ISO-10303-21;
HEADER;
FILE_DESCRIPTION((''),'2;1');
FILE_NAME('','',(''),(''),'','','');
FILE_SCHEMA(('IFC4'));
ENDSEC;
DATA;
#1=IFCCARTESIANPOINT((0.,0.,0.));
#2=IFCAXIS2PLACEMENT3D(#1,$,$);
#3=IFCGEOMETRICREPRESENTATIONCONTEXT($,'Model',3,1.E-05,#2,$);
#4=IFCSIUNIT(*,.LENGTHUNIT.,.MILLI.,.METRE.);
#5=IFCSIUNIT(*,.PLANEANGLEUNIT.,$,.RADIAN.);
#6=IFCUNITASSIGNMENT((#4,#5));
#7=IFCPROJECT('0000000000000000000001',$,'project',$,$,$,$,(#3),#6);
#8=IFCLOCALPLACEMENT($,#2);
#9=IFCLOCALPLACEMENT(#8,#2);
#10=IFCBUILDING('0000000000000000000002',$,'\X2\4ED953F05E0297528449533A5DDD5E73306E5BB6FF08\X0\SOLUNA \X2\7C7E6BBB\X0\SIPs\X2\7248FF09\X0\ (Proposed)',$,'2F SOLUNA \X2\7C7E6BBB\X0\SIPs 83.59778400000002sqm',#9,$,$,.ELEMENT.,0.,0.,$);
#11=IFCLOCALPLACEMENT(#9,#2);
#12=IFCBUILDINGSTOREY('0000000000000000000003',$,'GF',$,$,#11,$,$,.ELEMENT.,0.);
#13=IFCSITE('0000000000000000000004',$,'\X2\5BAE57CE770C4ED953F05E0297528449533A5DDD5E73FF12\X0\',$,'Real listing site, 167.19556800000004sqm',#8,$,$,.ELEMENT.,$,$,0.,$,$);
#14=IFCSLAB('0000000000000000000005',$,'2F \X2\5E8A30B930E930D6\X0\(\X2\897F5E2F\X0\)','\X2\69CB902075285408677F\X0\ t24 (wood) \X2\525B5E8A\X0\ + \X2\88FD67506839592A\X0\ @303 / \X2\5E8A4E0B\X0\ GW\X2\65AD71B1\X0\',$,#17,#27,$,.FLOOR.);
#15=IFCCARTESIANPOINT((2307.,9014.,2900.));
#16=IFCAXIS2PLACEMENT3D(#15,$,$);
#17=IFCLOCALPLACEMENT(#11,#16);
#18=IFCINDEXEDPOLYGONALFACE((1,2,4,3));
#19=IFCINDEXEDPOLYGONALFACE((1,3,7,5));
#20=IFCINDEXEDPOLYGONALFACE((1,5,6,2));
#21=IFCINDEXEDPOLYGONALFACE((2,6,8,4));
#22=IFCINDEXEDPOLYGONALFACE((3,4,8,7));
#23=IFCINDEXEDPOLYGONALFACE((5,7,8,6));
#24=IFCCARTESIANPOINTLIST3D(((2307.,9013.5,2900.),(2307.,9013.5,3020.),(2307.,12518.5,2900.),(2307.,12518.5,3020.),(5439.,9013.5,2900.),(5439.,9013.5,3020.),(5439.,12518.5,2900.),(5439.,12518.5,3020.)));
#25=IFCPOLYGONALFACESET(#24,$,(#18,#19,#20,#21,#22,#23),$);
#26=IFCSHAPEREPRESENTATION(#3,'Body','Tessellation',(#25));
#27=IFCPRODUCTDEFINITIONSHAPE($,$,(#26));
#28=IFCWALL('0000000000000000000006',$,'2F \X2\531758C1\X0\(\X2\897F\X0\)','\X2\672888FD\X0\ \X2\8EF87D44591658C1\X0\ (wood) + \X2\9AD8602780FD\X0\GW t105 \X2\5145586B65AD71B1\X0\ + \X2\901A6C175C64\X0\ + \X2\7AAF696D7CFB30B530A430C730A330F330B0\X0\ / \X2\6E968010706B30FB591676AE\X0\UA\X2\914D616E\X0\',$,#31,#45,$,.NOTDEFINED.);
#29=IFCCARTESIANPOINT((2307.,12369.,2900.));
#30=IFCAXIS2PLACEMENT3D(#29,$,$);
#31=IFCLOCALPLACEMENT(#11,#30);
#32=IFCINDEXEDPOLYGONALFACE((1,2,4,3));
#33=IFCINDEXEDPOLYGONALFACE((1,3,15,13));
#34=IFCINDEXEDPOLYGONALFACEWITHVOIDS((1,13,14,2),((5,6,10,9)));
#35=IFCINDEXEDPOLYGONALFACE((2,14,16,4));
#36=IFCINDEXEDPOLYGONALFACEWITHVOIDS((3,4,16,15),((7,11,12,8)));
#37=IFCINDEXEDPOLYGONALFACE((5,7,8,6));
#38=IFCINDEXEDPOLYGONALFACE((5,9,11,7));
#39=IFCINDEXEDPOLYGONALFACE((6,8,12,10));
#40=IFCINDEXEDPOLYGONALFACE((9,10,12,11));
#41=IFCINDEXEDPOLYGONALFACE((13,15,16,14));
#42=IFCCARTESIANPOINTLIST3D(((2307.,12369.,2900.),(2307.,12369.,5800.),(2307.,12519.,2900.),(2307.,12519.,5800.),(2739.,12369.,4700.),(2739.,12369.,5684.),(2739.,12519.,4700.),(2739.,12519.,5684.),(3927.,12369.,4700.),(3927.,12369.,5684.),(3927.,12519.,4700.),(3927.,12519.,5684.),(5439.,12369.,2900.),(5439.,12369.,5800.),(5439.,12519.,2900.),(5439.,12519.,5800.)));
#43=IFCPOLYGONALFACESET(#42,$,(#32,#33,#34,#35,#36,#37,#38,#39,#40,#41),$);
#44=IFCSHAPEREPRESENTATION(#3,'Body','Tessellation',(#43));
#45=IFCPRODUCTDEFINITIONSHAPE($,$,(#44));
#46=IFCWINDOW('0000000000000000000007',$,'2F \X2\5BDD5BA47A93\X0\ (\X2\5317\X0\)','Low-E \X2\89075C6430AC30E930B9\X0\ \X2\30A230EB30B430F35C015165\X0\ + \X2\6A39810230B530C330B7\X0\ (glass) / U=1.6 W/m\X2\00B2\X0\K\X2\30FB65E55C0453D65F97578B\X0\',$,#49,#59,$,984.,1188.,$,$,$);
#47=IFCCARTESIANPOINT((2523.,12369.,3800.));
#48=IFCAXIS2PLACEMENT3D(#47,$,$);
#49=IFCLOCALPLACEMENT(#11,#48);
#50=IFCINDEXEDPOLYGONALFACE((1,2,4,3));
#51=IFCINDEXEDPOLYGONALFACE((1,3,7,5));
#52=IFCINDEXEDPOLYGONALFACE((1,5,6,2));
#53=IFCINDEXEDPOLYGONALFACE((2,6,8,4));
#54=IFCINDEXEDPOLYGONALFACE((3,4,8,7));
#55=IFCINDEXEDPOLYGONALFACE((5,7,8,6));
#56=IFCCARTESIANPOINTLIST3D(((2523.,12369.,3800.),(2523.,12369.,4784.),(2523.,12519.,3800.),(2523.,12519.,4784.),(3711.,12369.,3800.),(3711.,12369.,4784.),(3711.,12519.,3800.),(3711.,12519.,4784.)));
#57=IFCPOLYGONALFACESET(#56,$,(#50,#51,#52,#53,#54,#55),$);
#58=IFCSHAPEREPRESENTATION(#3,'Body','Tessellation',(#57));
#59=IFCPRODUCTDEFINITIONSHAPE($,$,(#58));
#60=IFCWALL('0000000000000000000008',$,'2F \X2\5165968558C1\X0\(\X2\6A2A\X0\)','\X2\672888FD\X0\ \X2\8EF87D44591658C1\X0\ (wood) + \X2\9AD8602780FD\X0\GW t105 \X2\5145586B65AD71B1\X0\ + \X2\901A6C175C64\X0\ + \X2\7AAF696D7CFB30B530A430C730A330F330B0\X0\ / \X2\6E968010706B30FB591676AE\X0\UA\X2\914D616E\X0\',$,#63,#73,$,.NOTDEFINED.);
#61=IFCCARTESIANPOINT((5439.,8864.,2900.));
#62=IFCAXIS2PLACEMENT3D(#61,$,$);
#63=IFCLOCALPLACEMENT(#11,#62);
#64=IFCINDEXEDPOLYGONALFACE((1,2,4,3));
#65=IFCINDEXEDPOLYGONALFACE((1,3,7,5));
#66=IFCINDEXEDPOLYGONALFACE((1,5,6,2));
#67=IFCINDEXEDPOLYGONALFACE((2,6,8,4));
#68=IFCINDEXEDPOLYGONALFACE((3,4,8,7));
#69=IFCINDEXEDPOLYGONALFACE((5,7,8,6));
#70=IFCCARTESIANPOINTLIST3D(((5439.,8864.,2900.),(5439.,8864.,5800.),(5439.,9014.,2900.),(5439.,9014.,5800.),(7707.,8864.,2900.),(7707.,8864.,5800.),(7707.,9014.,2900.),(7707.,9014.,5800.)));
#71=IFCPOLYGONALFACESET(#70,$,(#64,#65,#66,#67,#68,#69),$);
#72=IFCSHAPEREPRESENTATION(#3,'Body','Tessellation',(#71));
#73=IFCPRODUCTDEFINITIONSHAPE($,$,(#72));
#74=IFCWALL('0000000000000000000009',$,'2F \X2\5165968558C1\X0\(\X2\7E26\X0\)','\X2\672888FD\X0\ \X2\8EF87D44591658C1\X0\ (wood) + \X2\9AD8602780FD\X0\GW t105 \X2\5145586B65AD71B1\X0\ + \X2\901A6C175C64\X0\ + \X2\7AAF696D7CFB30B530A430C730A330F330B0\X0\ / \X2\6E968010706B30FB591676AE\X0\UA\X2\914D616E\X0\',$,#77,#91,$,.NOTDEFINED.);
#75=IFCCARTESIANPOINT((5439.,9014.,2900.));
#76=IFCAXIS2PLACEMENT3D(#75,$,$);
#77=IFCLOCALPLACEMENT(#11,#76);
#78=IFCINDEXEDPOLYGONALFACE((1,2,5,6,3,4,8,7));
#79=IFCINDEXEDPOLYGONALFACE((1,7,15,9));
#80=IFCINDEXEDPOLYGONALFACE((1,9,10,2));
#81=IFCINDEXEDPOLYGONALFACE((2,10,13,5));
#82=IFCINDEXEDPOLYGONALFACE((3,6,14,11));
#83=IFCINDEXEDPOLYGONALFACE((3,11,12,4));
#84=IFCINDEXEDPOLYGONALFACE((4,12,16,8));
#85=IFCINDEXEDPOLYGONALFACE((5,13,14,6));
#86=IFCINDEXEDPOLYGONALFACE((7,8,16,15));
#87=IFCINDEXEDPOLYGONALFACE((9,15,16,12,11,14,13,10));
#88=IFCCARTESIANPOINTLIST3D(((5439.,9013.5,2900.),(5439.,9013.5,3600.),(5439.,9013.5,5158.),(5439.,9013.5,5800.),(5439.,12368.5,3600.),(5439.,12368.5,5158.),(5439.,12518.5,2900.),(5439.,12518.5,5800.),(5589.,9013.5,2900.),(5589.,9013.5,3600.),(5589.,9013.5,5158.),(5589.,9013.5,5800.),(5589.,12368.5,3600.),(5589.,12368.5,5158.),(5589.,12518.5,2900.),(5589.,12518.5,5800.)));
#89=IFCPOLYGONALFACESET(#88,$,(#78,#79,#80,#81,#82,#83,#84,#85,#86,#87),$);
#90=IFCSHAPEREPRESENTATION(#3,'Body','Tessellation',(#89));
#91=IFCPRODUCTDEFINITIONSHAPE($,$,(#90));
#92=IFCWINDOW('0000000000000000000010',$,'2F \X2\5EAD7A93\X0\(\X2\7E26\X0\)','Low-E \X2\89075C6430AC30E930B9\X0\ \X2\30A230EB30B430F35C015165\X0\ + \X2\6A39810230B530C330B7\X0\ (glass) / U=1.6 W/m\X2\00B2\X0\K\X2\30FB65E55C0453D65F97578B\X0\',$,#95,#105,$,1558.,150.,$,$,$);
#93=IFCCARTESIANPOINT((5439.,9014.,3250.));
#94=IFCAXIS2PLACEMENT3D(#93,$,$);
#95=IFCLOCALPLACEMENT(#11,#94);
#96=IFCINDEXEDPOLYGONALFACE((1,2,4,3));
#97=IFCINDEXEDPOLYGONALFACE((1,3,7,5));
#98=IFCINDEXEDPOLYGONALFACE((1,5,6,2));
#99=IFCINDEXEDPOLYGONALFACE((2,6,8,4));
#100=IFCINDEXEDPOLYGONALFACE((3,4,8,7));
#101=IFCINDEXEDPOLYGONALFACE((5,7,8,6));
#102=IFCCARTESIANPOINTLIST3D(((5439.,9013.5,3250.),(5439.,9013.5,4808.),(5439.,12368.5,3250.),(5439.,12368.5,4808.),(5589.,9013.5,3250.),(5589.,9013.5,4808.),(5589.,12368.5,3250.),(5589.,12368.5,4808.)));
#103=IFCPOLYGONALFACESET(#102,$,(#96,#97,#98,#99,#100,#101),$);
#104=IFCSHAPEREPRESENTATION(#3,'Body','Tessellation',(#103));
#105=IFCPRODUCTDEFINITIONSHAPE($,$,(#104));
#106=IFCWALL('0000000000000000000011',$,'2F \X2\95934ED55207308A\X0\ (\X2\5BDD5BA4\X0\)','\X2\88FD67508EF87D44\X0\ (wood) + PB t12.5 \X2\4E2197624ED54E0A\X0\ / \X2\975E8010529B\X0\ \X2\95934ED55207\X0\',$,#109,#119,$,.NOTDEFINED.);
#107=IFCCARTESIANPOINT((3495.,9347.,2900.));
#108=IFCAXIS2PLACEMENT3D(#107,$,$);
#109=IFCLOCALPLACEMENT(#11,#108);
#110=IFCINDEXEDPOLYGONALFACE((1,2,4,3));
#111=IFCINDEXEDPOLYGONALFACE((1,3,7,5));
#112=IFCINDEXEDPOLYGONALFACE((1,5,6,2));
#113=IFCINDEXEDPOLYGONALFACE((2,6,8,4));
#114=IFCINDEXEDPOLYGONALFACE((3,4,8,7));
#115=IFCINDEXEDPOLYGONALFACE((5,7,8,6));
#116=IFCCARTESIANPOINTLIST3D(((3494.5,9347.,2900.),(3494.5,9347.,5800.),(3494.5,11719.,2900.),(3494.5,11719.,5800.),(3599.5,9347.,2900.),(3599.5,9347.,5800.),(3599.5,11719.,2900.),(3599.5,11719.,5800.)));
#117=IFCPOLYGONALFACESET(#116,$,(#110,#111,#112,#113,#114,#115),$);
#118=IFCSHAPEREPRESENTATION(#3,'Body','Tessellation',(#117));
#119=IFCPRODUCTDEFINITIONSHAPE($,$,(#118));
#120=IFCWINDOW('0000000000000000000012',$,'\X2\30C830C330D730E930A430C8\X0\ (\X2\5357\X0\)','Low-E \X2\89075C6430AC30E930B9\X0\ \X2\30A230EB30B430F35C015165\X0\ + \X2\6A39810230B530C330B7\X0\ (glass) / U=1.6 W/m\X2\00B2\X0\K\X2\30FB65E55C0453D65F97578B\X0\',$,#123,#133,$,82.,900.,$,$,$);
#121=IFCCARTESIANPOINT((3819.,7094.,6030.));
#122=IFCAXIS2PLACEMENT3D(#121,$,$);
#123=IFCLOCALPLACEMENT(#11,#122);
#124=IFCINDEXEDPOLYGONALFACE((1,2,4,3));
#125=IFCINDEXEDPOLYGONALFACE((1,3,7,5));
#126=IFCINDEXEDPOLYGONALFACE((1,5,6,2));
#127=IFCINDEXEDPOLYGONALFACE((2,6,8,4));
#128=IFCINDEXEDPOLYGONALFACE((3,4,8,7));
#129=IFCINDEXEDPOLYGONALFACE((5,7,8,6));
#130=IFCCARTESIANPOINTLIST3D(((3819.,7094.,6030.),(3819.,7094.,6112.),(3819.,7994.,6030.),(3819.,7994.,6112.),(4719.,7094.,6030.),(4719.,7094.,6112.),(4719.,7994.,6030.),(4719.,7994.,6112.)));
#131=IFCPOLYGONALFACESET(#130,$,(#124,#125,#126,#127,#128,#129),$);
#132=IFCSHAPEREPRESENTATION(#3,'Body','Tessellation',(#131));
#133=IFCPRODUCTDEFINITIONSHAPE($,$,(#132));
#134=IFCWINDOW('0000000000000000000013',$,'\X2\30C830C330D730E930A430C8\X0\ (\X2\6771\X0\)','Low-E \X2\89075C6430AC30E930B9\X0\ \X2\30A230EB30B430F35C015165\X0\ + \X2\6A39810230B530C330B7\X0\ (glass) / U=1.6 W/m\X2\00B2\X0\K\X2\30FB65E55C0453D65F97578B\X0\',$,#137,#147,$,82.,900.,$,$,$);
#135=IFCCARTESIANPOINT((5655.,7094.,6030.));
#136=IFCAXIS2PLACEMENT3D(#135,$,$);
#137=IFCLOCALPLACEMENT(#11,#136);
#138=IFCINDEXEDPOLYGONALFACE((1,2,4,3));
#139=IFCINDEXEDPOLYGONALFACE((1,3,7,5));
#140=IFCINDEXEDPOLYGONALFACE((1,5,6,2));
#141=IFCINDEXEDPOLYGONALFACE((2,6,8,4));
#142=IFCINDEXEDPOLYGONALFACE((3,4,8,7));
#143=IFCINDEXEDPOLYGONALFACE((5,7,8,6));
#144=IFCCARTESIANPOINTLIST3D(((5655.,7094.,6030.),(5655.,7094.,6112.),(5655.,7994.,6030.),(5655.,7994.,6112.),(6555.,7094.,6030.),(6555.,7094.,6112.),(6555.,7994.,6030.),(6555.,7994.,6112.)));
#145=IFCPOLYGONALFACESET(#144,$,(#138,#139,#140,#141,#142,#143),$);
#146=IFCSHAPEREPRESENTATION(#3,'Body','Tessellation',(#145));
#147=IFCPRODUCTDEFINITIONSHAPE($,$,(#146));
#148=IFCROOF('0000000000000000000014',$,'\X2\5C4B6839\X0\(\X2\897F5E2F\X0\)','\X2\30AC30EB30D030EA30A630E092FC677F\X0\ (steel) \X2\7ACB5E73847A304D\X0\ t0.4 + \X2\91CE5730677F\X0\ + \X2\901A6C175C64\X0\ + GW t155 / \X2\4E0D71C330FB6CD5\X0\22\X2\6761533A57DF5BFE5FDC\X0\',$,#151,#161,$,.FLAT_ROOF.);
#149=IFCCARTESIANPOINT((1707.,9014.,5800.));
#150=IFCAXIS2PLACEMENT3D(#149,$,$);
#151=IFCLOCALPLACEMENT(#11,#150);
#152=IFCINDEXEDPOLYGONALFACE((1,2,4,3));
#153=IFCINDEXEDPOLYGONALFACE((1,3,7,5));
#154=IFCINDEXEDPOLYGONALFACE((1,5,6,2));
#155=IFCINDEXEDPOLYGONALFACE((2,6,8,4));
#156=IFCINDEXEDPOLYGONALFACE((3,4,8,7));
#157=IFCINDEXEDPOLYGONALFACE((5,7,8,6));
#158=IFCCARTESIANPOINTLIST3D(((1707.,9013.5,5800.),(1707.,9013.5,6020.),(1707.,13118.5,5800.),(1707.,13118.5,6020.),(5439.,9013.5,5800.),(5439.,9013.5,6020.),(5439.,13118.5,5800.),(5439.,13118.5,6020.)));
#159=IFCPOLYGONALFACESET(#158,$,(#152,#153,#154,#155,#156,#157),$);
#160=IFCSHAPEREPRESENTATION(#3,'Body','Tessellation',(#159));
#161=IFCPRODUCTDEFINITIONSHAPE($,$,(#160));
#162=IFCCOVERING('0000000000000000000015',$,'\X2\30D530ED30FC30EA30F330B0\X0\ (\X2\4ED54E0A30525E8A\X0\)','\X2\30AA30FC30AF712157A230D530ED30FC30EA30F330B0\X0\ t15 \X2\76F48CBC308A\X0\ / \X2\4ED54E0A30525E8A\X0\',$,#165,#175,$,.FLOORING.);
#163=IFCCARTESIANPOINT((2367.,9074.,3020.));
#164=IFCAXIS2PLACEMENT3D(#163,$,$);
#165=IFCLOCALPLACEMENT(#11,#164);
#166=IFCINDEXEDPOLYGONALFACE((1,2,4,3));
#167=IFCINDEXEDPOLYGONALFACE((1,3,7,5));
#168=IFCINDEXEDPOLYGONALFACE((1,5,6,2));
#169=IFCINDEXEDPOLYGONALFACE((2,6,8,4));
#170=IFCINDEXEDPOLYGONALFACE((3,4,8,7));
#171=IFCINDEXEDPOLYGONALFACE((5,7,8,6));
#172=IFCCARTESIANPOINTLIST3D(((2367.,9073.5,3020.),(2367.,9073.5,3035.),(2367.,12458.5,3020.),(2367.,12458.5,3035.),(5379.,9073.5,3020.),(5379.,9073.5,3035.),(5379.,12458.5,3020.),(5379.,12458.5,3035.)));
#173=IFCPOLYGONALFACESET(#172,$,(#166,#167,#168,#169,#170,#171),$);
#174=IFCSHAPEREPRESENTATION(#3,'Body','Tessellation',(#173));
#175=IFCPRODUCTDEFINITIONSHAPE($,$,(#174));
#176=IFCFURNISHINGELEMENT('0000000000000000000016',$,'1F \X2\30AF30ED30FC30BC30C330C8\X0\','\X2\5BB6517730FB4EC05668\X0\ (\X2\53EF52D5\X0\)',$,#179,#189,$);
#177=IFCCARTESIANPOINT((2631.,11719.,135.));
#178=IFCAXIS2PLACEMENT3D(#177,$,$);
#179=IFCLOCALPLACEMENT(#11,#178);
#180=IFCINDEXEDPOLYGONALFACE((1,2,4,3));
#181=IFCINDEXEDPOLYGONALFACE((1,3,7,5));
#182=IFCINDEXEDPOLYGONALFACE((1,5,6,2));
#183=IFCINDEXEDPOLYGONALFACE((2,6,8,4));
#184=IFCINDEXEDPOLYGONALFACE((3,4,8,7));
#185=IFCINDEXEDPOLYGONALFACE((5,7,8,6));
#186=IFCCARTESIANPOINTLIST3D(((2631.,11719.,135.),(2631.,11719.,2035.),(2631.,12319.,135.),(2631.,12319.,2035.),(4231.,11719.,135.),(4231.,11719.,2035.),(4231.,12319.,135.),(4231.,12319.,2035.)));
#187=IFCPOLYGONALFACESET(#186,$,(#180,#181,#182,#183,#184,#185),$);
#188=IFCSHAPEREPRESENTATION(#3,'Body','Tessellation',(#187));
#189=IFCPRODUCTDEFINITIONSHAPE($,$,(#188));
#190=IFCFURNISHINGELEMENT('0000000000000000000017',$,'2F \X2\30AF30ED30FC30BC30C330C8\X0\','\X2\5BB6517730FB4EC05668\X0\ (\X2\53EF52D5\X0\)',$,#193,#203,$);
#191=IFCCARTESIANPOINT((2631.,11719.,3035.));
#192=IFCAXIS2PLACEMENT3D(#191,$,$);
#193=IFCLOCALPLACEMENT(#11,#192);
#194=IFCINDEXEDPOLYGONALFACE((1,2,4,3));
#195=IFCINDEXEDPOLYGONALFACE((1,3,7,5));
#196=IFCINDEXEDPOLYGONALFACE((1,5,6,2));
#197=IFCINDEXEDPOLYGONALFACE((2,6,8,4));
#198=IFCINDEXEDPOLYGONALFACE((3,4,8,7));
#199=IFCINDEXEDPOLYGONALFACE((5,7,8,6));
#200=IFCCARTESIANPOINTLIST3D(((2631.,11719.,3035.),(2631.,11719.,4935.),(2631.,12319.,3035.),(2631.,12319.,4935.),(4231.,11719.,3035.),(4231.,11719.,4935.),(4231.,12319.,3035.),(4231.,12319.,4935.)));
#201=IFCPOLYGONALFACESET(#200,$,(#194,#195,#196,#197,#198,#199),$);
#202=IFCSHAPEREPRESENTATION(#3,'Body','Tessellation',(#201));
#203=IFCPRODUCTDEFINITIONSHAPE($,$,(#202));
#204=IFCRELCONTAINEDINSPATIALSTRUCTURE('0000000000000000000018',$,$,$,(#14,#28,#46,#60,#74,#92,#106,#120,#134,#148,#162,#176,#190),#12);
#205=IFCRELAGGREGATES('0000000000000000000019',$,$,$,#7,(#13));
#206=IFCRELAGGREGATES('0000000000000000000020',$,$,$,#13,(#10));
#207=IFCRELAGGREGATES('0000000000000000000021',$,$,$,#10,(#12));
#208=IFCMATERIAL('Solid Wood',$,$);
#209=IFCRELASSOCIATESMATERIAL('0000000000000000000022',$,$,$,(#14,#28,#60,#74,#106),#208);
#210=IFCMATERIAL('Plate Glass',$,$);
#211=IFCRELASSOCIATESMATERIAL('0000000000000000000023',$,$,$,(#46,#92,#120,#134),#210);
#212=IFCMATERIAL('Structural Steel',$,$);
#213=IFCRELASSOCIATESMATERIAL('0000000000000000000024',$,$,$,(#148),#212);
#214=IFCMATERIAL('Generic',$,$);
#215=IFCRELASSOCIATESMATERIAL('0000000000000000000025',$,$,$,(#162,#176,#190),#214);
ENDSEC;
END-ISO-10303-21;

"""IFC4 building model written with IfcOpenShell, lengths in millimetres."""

from ifc_helpers import new_model, si_unit, frame, frame_2d, origin, place, context, project, spatial, rectangle, extrude, material, element, fill, save


model = new_model("IFC4")

# Units and contexts
model_context = context("Model", 3, precision=1e-05, world=origin())
ifc_project = project(units=[si_unit("LENGTHUNIT", "METRE", prefix="MILLI"), si_unit("PLANEANGLEUNIT", "RADIAN")], contexts=[model_context])

# Site, building, storey
site_placement = place(None, origin())
site = spatial("IfcSite", under=ifc_project, at=site_placement, Name="宮城県仙台市青葉区川平２", ObjectType="Real listing site, 167.19556800000004sqm", CompositionType="ELEMENT", RefElevation=0.0)
building_placement = place(site_placement, origin())
building = spatial("IfcBuilding", under=site, at=building_placement, Name="仙台市青葉区川平の家（SOLUNA 籾殻SIPs版） (Proposed)", ObjectType="2F SOLUNA 籾殻SIPs 83.59778400000002sqm", CompositionType="ELEMENT", ElevationOfRefHeight=0.0, ElevationOfTerrain=0.0)
storey_placement = place(building_placement, origin())
storey = spatial("IfcBuildingStorey", under=building, at=storey_placement, Name="GF", CompositionType="ELEMENT", Elevation=0.0)

# Slab
ifc_material_1 = material(Name="Solid Wood")
slab_placement = place(storey_placement, frame((2307.0, 9014.0, 2900.0)))
element("IfcSlab", 1, at=slab_placement, inside=storey, material=ifc_material_1, Name="2F 床スラブ(西帯)", Description="構造用合板 t24 (wood) 剛床 + 製材根太 @303 / 床下 GW断熱", PredefinedType="FLOOR", context=model_context, shape_type="SweptSolid", body=[
    extrude(rectangle(XDim=3132.0, YDim=3505.0, at=frame_2d((1566.0, 1752.0))), frame((2307.0, 9014.0, 2900.0)), (0.0, 0.0, 1.0), 120.0),
])

# Wall, opening, window
wall_1_placement = place(storey_placement, frame((2307.0, 12369.0, 2900.0)))
wall_1 = element("IfcWall", 2, at=wall_1_placement, inside=storey, material=ifc_material_1, Name="2F 北壁(西)", Description="木製 軸組外壁 (wood) + 高性能GW t105 充填断熱 + 通気層 + 窯業系サイディング / 準耐火・外皮UA配慮", PredefinedType="NOTDEFINED", context=model_context, shape_type="SweptSolid", body=[
    extrude(rectangle(XDim=3132.0, YDim=150.0, at=frame_2d((1566.0, 75.0))), frame((2307.0, 12369.0, 2900.0)), (0.0, 0.0, 1.0), 2900.0),
])
opening_1_placement = place(storey_placement, frame((2523.0, 12369.0, 3800.0)))
opening_1 = element("IfcOpeningElement", 3, at=opening_1_placement, cuts=wall_1, PredefinedType="NOTDEFINED", context=model_context, shape_type="SweptSolid", body=[
    extrude(rectangle(XDim=1188.0, YDim=150.0, at=frame_2d((594.0, 75.0))), frame((2523.0, 12369.0, 3800.0)), (0.0, 0.0, 1.0), 984.0),
])
ifc_material_2 = material(Name="Plate Glass")
window_1_placement = place(storey_placement, frame((2523.0, 12369.0, 3800.0)))
window_1 = element("IfcWindow", 4, at=window_1_placement, inside=storey, material=ifc_material_2, Name="2F 寝室窓 (北)", Description="Low-E 複層ガラス アルゴン封入 + 樹脂サッシ (glass) / U=1.6 W/m²K・日射取得型", OverallHeight=984.0, OverallWidth=1188.0, context=model_context, shape_type="SweptSolid", body=[
    extrude(rectangle(XDim=1188.0, YDim=150.0, at=frame_2d((594.0, 75.0))), frame((2523.0, 12369.0, 3800.0)), (0.0, 0.0, 1.0), 984.0),
])
fill(opening_1, window_1)

# Wall
wall_2_placement = place(storey_placement, frame((5439.0, 8864.0, 2900.0)))
element("IfcWall", 5, at=wall_2_placement, inside=storey, material=ifc_material_1, Name="2F 入隅壁(横)", Description="木製 軸組外壁 (wood) + 高性能GW t105 充填断熱 + 通気層 + 窯業系サイディング / 準耐火・外皮UA配慮", PredefinedType="NOTDEFINED", context=model_context, shape_type="SweptSolid", body=[
    extrude(rectangle(XDim=2268.0, YDim=150.0, at=frame_2d((1134.0, 75.0))), frame((5439.0, 8864.0, 2900.0)), (0.0, 0.0, 1.0), 2900.0),
])

# Wall, opening, window
wall_3_placement = place(storey_placement, frame((5439.0, 9014.0, 2900.0)))
wall_3 = element("IfcWall", 6, at=wall_3_placement, inside=storey, material=ifc_material_1, Name="2F 入隅壁(縦)", Description="木製 軸組外壁 (wood) + 高性能GW t105 充填断熱 + 通気層 + 窯業系サイディング / 準耐火・外皮UA配慮", PredefinedType="NOTDEFINED", context=model_context, shape_type="SweptSolid", body=[
    extrude(rectangle(XDim=150.0, YDim=3505.0, at=frame_2d((75.0, 1752.0))), frame((5439.0, 9014.0, 2900.0)), (0.0, 0.0, 1.0), 2900.0),
])
opening_2_placement = place(storey_placement, frame((5439.0, 9014.0, 3250.0)))
opening_2 = element("IfcOpeningElement", 7, at=opening_2_placement, cuts=wall_3, PredefinedType="NOTDEFINED", context=model_context, shape_type="SweptSolid", body=[
    extrude(rectangle(XDim=150.0, YDim=3355.0, at=frame_2d((75.0, 1677.0))), frame((5439.0, 9014.0, 3250.0)), (0.0, 0.0, 1.0), 1558.0),
])
window_2_placement = place(storey_placement, frame((5439.0, 9014.0, 3250.0)))
window_2 = element("IfcWindow", 8, at=window_2_placement, inside=storey, material=ifc_material_2, Name="2F 庭窓(縦)", Description="Low-E 複層ガラス アルゴン封入 + 樹脂サッシ (glass) / U=1.6 W/m²K・日射取得型", OverallHeight=1558.0, OverallWidth=150.0, context=model_context, shape_type="SweptSolid", body=[
    extrude(rectangle(XDim=150.0, YDim=3355.0, at=frame_2d((75.0, 1677.0))), frame((5439.0, 9014.0, 3250.0)), (0.0, 0.0, 1.0), 1558.0),
])
fill(opening_2, window_2)

# Wall
wall_4_placement = place(storey_placement, frame((3495.0, 9347.0, 2900.0)))
element("IfcWall", 9, at=wall_4_placement, inside=storey, material=ifc_material_1, Name="2F 間仕切り (寝室)", Description="製材軸組 (wood) + PB t12.5 両面仕上 / 非耐力 間仕切", PredefinedType="NOTDEFINED", context=model_context, shape_type="SweptSolid", body=[
    extrude(rectangle(XDim=105.0, YDim=2372.0, at=frame_2d((52.0, 1186.0))), frame((3495.0, 9347.0, 2900.0)), (0.0, 0.0, 1.0), 2900.0),
])

# Windows
window_3_placement = place(storey_placement, frame((3819.0, 7094.0, 6030.0)))
element("IfcWindow", 10, at=window_3_placement, inside=storey, material=ifc_material_2, Name="トップライト (南)", Description="Low-E 複層ガラス アルゴン封入 + 樹脂サッシ (glass) / U=1.6 W/m²K・日射取得型", OverallHeight=82.0, OverallWidth=900.0, context=model_context, shape_type="SweptSolid", body=[
    extrude(rectangle(XDim=900.0, YDim=900.0, at=frame_2d((450.0, 450.0))), frame((3819.0, 7094.0, 6030.0)), (0.0, 0.0, 1.0), 82.0),
])
window_4_placement = place(storey_placement, frame((5655.0, 7094.0, 6030.0)))
element("IfcWindow", 11, at=window_4_placement, inside=storey, material=ifc_material_2, Name="トップライト (東)", Description="Low-E 複層ガラス アルゴン封入 + 樹脂サッシ (glass) / U=1.6 W/m²K・日射取得型", OverallHeight=82.0, OverallWidth=900.0, context=model_context, shape_type="SweptSolid", body=[
    extrude(rectangle(XDim=900.0, YDim=900.0, at=frame_2d((450.0, 450.0))), frame((5655.0, 7094.0, 6030.0)), (0.0, 0.0, 1.0), 82.0),
])

# Roof
ifc_material_3 = material(Name="Structural Steel")
for number, where, name in (
    (12, (1707.0, 9014.0, 5800.0), "屋根(西帯)"),
):
    element("IfcRoof", number, at=place(storey_placement, frame(where)), inside=storey, material=ifc_material_3, Name=name, Description="ガルバリウム鋼板 (steel) 立平葺き t0.4 + 野地板 + 通気層 + GW t155 / 不燃・法22条区域対応", PredefinedType="FLAT_ROOF", context=model_context, shape_type="SweptSolid", body=[
        extrude(rectangle(XDim=3732.0, YDim=4105.0, at=frame_2d((1866.0, 2052.0))), frame((1707.0, 9014.0, 5800.0)), (0.0, 0.0, 1.0), 220.0),
    ])

# Covering
ifc_material_4 = material(Name="Generic")
covering_placement = place(storey_placement, frame((2367.0, 9074.0, 3020.0)))
element("IfcCovering", 13, at=covering_placement, inside=storey, material=ifc_material_4, Name="フローリング (仕上げ床)", Description="オーク無垢フローリング t15 直貼り / 仕上げ床", PredefinedType="FLOORING", context=model_context, shape_type="SweptSolid", body=[
    extrude(rectangle(XDim=3012.0, YDim=3385.0, at=frame_2d((1506.0, 1692.0))), frame((2367.0, 9074.0, 3020.0)), (0.0, 0.0, 1.0), 15.0),
])

# Furnishing elements
furnishing_1_placement = place(storey_placement, frame((2631.0, 11719.0, 135.0)))
element("IfcFurnishingElement", 14, at=furnishing_1_placement, inside=storey, material=ifc_material_4, Name="1F クローゼット", Description="家具・什器 (可動)", context=model_context, shape_type="SweptSolid", body=[
    extrude(rectangle(XDim=1600.0, YDim=600.0, at=frame_2d((800.0, 300.0))), frame((2631.0, 11719.0, 135.0)), (0.0, 0.0, 1.0), 1900.0),
])
furnishing_2_placement = place(storey_placement, frame((2631.0, 11719.0, 3035.0)))
element("IfcFurnishingElement", 15, at=furnishing_2_placement, inside=storey, material=ifc_material_4, Name="2F クローゼット", Description="家具・什器 (可動)", context=model_context, shape_type="SweptSolid", body=[
    extrude(rectangle(XDim=1600.0, YDim=600.0, at=frame_2d((800.0, 300.0))), frame((2631.0, 11719.0, 3035.0)), (0.0, 0.0, 1.0), 1900.0),
])

save(model, "model.ifc")
